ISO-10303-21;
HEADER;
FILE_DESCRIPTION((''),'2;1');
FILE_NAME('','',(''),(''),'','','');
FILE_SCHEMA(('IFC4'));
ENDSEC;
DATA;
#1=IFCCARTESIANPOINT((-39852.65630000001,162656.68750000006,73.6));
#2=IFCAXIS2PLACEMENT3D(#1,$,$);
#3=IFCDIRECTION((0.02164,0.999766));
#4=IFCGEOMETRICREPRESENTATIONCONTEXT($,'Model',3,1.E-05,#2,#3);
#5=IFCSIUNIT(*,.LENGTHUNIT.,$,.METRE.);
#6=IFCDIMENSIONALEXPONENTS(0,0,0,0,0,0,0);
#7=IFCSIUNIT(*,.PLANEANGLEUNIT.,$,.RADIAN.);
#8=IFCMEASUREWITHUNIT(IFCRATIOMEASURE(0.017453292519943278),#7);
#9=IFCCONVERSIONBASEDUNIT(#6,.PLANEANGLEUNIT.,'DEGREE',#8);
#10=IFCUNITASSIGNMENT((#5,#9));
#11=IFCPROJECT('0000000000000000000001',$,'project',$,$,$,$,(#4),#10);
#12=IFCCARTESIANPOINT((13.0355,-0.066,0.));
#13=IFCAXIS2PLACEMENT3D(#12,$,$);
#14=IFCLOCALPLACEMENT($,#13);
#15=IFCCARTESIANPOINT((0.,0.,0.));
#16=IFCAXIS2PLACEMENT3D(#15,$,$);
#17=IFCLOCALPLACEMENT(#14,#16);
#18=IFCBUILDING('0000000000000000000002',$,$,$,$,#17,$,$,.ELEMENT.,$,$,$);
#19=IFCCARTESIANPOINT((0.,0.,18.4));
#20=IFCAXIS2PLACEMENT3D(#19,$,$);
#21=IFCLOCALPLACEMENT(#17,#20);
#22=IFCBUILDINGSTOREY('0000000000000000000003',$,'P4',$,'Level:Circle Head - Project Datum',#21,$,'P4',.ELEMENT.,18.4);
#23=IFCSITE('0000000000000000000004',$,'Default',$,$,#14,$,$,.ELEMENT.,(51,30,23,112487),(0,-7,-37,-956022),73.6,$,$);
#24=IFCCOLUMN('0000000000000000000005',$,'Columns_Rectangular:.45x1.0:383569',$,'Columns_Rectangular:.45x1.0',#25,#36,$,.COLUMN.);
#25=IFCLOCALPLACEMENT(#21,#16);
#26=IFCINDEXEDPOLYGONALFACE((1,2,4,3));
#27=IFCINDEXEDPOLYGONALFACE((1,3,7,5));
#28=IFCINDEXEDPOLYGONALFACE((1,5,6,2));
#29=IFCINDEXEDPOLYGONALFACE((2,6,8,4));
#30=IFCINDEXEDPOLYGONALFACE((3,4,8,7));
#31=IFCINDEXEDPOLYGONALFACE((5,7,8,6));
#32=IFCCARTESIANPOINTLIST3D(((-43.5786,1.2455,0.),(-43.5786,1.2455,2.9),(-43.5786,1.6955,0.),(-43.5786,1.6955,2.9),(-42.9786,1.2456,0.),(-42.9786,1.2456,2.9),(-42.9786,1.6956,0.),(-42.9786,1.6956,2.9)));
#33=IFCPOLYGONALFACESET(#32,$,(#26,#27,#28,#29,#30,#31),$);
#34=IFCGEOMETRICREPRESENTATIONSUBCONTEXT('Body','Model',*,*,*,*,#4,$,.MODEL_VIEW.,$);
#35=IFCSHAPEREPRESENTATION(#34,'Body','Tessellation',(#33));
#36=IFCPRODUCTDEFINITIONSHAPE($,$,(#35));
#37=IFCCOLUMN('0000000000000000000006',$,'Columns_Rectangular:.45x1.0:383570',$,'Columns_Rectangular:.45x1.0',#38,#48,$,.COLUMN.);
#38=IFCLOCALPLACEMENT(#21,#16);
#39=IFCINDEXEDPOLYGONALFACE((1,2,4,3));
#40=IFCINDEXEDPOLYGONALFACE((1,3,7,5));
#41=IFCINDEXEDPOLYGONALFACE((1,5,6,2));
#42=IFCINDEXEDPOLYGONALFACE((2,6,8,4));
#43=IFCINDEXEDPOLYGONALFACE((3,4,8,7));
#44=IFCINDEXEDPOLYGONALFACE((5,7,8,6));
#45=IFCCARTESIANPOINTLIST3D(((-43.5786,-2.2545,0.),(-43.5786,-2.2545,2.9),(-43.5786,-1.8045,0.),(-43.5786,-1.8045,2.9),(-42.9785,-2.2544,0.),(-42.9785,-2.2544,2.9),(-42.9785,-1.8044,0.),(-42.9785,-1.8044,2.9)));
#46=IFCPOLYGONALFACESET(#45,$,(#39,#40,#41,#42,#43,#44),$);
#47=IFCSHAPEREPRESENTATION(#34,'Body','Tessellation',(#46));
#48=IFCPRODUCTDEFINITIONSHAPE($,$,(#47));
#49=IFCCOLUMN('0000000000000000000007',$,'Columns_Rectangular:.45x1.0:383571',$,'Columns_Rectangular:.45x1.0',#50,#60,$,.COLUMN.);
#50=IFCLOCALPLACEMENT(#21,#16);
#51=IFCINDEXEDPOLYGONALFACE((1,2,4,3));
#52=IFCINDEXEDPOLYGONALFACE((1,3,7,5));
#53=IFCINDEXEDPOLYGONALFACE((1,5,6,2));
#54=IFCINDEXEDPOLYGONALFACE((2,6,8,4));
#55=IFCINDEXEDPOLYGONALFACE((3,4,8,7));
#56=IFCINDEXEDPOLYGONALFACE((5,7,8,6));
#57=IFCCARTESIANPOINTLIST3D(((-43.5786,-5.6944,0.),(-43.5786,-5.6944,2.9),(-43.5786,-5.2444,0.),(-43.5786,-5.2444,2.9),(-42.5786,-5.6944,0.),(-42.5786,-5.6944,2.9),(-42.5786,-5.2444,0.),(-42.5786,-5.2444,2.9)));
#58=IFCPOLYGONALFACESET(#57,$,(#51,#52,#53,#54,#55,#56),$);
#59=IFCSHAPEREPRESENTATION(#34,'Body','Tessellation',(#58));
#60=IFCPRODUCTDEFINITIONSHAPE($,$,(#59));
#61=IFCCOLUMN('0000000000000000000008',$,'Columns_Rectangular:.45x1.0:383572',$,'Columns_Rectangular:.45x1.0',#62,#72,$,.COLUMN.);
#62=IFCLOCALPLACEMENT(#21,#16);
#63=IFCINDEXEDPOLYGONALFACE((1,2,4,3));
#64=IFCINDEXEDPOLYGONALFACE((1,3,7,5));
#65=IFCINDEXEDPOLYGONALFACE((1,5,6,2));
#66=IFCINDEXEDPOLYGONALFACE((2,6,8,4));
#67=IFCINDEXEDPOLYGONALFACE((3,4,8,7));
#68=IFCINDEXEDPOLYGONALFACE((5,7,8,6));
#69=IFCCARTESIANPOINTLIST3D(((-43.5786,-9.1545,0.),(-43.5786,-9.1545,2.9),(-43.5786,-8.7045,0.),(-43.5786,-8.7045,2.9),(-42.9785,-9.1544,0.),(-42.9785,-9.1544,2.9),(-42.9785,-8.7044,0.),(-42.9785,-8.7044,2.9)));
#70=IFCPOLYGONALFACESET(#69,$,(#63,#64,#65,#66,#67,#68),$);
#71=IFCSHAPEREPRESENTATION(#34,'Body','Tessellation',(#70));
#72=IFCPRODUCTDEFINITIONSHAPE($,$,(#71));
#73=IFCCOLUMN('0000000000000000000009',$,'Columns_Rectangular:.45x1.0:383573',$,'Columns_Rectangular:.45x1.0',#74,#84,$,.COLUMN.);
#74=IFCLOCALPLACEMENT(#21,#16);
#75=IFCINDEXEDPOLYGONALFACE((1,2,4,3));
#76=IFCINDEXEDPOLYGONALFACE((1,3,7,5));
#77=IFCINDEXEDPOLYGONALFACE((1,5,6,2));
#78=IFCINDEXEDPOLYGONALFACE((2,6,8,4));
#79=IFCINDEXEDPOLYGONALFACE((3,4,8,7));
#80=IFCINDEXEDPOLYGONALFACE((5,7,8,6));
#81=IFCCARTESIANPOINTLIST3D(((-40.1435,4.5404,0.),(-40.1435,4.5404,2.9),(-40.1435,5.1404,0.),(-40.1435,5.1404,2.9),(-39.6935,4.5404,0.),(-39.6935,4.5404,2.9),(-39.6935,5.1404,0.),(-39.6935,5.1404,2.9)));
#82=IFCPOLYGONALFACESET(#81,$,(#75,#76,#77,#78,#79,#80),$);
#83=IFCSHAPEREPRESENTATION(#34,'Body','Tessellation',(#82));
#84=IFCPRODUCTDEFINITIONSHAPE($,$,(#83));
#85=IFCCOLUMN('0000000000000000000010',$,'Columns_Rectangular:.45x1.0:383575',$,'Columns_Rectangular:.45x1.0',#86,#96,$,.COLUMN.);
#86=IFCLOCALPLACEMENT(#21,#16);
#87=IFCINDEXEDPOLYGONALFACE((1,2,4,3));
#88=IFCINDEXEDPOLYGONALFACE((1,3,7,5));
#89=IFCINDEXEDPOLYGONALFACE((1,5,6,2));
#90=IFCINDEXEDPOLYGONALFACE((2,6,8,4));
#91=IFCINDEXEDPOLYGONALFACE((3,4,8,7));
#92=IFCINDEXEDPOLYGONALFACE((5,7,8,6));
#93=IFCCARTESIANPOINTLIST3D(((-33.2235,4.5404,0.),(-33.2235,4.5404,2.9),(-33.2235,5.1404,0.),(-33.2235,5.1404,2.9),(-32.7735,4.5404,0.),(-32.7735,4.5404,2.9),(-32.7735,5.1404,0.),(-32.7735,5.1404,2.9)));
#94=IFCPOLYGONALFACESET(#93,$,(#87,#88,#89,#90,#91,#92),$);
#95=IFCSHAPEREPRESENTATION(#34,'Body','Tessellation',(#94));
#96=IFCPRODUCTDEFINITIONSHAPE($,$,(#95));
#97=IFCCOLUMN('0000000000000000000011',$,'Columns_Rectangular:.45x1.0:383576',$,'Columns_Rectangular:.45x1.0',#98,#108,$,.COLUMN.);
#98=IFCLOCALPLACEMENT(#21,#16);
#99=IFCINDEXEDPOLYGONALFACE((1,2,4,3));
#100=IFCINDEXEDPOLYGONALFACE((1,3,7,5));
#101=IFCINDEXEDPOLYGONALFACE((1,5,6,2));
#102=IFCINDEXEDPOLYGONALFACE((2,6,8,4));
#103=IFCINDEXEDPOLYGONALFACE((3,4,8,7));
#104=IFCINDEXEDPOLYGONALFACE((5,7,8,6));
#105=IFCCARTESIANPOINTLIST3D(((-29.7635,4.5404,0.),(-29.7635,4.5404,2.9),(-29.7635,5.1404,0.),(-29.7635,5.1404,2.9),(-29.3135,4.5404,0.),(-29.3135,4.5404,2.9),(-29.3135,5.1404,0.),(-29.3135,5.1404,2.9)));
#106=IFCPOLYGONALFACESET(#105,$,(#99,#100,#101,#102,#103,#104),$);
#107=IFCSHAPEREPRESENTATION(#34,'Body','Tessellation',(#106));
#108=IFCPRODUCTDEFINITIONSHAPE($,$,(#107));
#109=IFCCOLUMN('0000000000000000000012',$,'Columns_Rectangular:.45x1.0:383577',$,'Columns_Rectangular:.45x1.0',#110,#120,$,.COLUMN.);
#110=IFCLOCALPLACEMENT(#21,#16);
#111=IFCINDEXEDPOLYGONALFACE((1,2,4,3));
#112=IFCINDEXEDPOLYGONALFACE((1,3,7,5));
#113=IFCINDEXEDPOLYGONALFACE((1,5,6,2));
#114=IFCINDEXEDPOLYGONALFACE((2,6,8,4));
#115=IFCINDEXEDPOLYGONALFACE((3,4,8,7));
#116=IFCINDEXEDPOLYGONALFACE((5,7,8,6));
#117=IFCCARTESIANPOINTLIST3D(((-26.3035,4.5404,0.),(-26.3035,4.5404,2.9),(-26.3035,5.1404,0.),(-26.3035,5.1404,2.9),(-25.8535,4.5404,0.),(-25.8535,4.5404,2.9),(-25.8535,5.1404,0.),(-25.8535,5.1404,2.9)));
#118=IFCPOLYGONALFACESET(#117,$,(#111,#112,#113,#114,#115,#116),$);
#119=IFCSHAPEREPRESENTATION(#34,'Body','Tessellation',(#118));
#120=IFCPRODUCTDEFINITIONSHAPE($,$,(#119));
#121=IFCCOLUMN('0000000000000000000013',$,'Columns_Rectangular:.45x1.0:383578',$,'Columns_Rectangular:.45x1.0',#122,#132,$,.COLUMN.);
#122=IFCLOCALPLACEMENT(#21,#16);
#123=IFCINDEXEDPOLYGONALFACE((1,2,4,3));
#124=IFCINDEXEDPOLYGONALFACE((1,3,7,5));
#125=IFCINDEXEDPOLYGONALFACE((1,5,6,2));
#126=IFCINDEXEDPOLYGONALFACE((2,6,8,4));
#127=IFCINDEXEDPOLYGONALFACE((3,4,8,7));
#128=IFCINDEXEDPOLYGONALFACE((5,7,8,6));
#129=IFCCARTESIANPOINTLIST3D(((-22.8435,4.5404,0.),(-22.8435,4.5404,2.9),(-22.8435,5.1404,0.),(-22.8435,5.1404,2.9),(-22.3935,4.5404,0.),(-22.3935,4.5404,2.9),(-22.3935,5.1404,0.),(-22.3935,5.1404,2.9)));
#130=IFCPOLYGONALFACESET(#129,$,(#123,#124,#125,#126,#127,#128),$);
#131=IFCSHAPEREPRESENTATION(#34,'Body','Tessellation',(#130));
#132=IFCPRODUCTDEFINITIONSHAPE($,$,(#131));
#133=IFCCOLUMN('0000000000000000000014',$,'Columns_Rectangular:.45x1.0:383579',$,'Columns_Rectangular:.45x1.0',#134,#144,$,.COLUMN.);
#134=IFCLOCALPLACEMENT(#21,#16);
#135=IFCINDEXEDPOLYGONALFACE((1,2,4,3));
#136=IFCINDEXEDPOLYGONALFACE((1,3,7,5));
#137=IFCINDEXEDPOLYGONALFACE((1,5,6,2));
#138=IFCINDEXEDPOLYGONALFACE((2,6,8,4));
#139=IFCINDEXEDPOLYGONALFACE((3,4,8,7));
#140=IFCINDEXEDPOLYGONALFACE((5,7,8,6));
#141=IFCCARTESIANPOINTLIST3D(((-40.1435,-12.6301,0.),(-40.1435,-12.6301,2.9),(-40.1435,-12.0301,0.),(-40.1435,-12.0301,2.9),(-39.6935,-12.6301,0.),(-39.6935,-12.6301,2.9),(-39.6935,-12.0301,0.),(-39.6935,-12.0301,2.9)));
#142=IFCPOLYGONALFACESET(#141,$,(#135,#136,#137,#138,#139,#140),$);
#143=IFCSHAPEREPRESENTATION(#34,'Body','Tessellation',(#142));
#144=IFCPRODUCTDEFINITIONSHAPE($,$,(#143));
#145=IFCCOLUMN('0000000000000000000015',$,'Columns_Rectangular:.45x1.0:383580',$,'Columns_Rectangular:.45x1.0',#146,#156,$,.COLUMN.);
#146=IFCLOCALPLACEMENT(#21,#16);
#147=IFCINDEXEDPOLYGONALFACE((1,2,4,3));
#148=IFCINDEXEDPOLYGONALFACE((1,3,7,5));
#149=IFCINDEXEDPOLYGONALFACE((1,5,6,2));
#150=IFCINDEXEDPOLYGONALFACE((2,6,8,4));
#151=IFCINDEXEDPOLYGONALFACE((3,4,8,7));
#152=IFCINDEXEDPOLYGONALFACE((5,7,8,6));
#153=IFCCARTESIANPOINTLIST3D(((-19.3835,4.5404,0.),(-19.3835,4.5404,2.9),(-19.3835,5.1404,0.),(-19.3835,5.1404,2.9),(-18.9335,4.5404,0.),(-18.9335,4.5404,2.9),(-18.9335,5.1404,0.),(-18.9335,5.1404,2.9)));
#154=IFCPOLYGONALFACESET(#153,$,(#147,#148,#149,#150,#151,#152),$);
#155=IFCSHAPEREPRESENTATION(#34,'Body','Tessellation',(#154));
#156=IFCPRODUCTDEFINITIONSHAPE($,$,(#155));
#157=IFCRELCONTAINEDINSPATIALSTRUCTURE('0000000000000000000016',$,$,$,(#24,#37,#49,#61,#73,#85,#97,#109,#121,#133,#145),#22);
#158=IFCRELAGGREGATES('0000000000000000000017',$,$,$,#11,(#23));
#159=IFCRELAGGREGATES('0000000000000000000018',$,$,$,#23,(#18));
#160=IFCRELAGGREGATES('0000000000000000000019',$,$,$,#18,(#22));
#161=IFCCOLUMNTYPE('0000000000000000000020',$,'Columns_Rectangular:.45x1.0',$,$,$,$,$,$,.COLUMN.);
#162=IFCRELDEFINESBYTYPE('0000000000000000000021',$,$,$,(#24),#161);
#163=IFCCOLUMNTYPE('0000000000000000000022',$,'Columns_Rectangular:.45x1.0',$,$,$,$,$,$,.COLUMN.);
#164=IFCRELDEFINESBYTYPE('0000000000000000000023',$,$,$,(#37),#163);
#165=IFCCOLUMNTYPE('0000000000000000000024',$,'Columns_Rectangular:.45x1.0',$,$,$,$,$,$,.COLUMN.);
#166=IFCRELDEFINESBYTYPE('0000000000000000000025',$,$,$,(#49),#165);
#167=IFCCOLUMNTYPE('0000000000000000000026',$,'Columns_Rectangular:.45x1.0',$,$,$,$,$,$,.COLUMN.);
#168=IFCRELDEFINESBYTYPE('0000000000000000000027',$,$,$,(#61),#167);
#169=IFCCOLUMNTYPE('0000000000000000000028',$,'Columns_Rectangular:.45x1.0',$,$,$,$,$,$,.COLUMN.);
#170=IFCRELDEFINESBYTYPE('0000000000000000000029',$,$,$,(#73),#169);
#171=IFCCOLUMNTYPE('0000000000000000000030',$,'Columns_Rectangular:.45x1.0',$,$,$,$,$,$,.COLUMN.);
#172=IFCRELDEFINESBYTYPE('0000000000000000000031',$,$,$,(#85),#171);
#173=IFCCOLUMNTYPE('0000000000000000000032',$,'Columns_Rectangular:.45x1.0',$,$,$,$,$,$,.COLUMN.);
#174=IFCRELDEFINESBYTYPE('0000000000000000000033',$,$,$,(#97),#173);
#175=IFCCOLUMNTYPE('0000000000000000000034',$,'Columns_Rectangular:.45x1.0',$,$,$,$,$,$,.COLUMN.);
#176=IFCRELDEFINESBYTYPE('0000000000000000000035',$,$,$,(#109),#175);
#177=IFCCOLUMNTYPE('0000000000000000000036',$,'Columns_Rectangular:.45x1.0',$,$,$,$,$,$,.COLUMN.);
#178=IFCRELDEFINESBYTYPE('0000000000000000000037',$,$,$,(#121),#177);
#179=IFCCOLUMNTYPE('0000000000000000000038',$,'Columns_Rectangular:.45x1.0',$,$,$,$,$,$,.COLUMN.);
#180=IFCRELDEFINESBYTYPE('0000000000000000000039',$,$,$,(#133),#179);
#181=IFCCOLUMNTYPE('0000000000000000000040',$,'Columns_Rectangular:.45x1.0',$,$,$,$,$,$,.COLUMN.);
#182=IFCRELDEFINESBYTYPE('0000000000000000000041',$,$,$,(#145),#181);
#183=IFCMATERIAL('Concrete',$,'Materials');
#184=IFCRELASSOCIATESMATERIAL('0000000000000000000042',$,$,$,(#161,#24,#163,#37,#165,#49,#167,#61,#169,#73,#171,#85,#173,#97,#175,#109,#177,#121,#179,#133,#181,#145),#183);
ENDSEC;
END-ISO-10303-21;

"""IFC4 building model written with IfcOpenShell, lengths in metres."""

from ifc_helpers import new_model, entity, si_unit, converted_unit, direction, frame, origin, place, context, subcontext, project, spatial, indexed_curve, outline, extrude, source, transform, mapped, material, type_object, type_shapes, element, save


model = new_model("IFC4")

# Units and contexts
model_context = context("Model", 3, precision=1e-05, world=frame((-39852.65630000001, 162656.68750000006, 73.6)), true_north=direction((0.02164, 0.999766)))
body_context = subcontext(model_context, "Body", "Model", "MODEL_VIEW")
ifc_project = project(units=[si_unit("LENGTHUNIT", "METRE"), converted_unit("PLANEANGLEUNIT", "DEGREE", entity("IfcRatioMeasure", 0.017453292519943278), si_unit("PLANEANGLEUNIT", "RADIAN"), dimensions=[0, 0, 0, 0, 0, 0, 0])], contexts=[model_context])

# Site, building, storey
site_placement = place(None, frame((13.0355, -0.066, 0.0)))
site = spatial("IfcSite", under=ifc_project, at=site_placement, Name="Default", CompositionType="ELEMENT", RefLatitude=(51, 30, 23, 112487), RefLongitude=(0, -7, -37, -956022), RefElevation=73.6)
building_placement = place(site_placement, origin())
building = spatial("IfcBuilding", under=site, at=building_placement, CompositionType="ELEMENT")
storey_placement = place(building_placement, frame((0.0, 0.0, 18.4)))
storey = spatial("IfcBuildingStorey", under=building, at=storey_placement, Name="P4", ObjectType="Level:Circle Head - Project Datum", LongName="P4", CompositionType="ELEMENT", Elevation=18.4)

# Columns
ifc_material = material(Name="Concrete", Category="Materials")
column_type_1 = type_object("IfcColumnType", Name="Columns_Rectangular:.45x1.0", PredefinedType="COLUMN", material=ifc_material)
shared_shape_1 = source(origin(), body_context, "Body", "SweptSolid", [
    extrude(outline(indexed_curve([(-0.3, -0.225), (0.3, -0.225), (0.3, 0.225), (-0.3, 0.225), (-0.3, -0.225)], self_intersect=False)), frame((-43.2786, 1.4706, 18.4), z_axis=(0.0, 0.0, 1.0), x_axis=(-1.0, -0.000005, 0.0)), (0.0, 0.0, 1.0), 2.9),
])
type_shapes(column_type_1, [shared_shape_1])
column_1_placement = place(storey_placement, frame((0.0, 0.0, -18.4)))
element("IfcColumn", 1, at=column_1_placement, inside=storey, type_object=column_type_1, material=ifc_material, Name="Columns_Rectangular:.45x1.0:383569", ObjectType="Columns_Rectangular:.45x1.0", PredefinedType="COLUMN", context=body_context, shape_type="MappedRepresentation", body=[
    mapped(shared_shape_1, transform((0.0, 0.0, 0.0), scale=1.0)),
])
column_type_2 = type_object("IfcColumnType", Name="Columns_Rectangular:.45x1.0", PredefinedType="COLUMN", material=ifc_material)
shared_shape_2 = source(origin(), body_context, "Body", "SweptSolid", [
    extrude(outline(indexed_curve([(-0.3, -0.225), (0.3, -0.225), (0.3, 0.225), (-0.3, 0.225), (-0.3, -0.225)], self_intersect=False)), frame((-43.2785, -2.0294, 18.4), z_axis=(0.0, 0.0, 1.0), x_axis=(-1.0, -0.000005, 0.0)), (0.0, 0.0, 1.0), 2.9),
])
type_shapes(column_type_2, [shared_shape_2])
column_2_placement = place(storey_placement, frame((0.0, 0.0, -18.4)))
element("IfcColumn", 2, at=column_2_placement, inside=storey, type_object=column_type_2, material=ifc_material, Name="Columns_Rectangular:.45x1.0:383570", ObjectType="Columns_Rectangular:.45x1.0", PredefinedType="COLUMN", context=body_context, shape_type="MappedRepresentation", body=[
    mapped(shared_shape_2, transform((0.0, 0.0, 0.0), scale=1.0)),
])
column_type_3 = type_object("IfcColumnType", Name="Columns_Rectangular:.45x1.0", PredefinedType="COLUMN", material=ifc_material)
shared_shape_3 = source(origin(), body_context, "Body", "SweptSolid", [
    extrude(outline(indexed_curve([(-0.225, -0.5), (0.225, -0.5), (0.225, 0.5), (-0.225, 0.5), (-0.225, -0.5)], self_intersect=False)), frame((-43.0786, -5.4694, 18.4), z_axis=(0.0, 0.0, 1.0), x_axis=(0.0, -1.0, 0.0)), (0.0, 0.0, 1.0), 2.9),
])
type_shapes(column_type_3, [shared_shape_3])
column_3_placement = place(storey_placement, frame((0.0, 0.0, -18.4)))
element("IfcColumn", 3, at=column_3_placement, inside=storey, type_object=column_type_3, material=ifc_material, Name="Columns_Rectangular:.45x1.0:383571", ObjectType="Columns_Rectangular:.45x1.0", PredefinedType="COLUMN", context=body_context, shape_type="MappedRepresentation", body=[
    mapped(shared_shape_3, transform((0.0, 0.0, 0.0), scale=1.0)),
])
column_type_4 = type_object("IfcColumnType", Name="Columns_Rectangular:.45x1.0", PredefinedType="COLUMN", material=ifc_material)
shared_shape_4 = source(origin(), body_context, "Body", "SweptSolid", [
    extrude(outline(indexed_curve([(-0.3, -0.225), (0.3, -0.225), (0.3, 0.225), (-0.3, 0.225), (-0.3, -0.225)], self_intersect=False)), frame((-43.2785, -8.9294, 18.4), z_axis=(0.0, 0.0, 1.0), x_axis=(-1.0, -0.000005, 0.0)), (0.0, 0.0, 1.0), 2.9),
])
type_shapes(column_type_4, [shared_shape_4])
column_4_placement = place(storey_placement, frame((0.0, 0.0, -18.4)))
element("IfcColumn", 4, at=column_4_placement, inside=storey, type_object=column_type_4, material=ifc_material, Name="Columns_Rectangular:.45x1.0:383572", ObjectType="Columns_Rectangular:.45x1.0", PredefinedType="COLUMN", context=body_context, shape_type="MappedRepresentation", body=[
    mapped(shared_shape_4, transform((0.0, 0.0, 0.0), scale=1.0)),
])
column_type_5 = type_object("IfcColumnType", Name="Columns_Rectangular:.45x1.0", PredefinedType="COLUMN", material=ifc_material)
shared_shape_5 = source(origin(), body_context, "Body", "SweptSolid", [
    extrude(outline(indexed_curve([(-0.3, -0.225), (0.3, -0.225), (0.3, 0.225), (-0.3, 0.225), (-0.3, -0.225)], self_intersect=False)), frame((-39.9185, 4.8404, 18.4), z_axis=(0.0, 0.0, 1.0), x_axis=(0.0, -1.0, 0.0)), (0.0, 0.0, 1.0), 2.9),
])
type_shapes(column_type_5, [shared_shape_5])
column_5_placement = place(storey_placement, frame((0.0, 0.0, -18.4)))
element("IfcColumn", 5, at=column_5_placement, inside=storey, type_object=column_type_5, material=ifc_material, Name="Columns_Rectangular:.45x1.0:383573", ObjectType="Columns_Rectangular:.45x1.0", PredefinedType="COLUMN", context=body_context, shape_type="MappedRepresentation", body=[
    mapped(shared_shape_5, transform((0.0, 0.0, 0.0), scale=1.0)),
])
column_type_6 = type_object("IfcColumnType", Name="Columns_Rectangular:.45x1.0", PredefinedType="COLUMN", material=ifc_material)
shared_shape_6 = source(origin(), body_context, "Body", "SweptSolid", [
    extrude(outline(indexed_curve([(-0.3, -0.225), (0.3, -0.225), (0.3, 0.225), (-0.3, 0.225), (-0.3, -0.225)], self_intersect=False)), frame((-32.9985, 4.8404, 18.4), z_axis=(0.0, 0.0, 1.0), x_axis=(0.0, -1.0, 0.0)), (0.0, 0.0, 1.0), 2.9),
])
type_shapes(column_type_6, [shared_shape_6])
column_6_placement = place(storey_placement, frame((0.0, 0.0, -18.4)))
element("IfcColumn", 6, at=column_6_placement, inside=storey, type_object=column_type_6, material=ifc_material, Name="Columns_Rectangular:.45x1.0:383575", ObjectType="Columns_Rectangular:.45x1.0", PredefinedType="COLUMN", context=body_context, shape_type="MappedRepresentation", body=[
    mapped(shared_shape_6, transform((0.0, 0.0, 0.0), scale=1.0)),
])
column_type_7 = type_object("IfcColumnType", Name="Columns_Rectangular:.45x1.0", PredefinedType="COLUMN", material=ifc_material)
shared_shape_7 = source(origin(), body_context, "Body", "SweptSolid", [
    extrude(outline(indexed_curve([(-0.3, -0.225), (0.3, -0.225), (0.3, 0.225), (-0.3, 0.225), (-0.3, -0.225)], self_intersect=False)), frame((-29.5385, 4.8404, 18.4), z_axis=(0.0, 0.0, 1.0), x_axis=(0.0, -1.0, 0.0)), (0.0, 0.0, 1.0), 2.9),
])
type_shapes(column_type_7, [shared_shape_7])
column_7_placement = place(storey_placement, frame((0.0, 0.0, -18.4)))
element("IfcColumn", 7, at=column_7_placement, inside=storey, type_object=column_type_7, material=ifc_material, Name="Columns_Rectangular:.45x1.0:383576", ObjectType="Columns_Rectangular:.45x1.0", PredefinedType="COLUMN", context=body_context, shape_type="MappedRepresentation", body=[
    mapped(shared_shape_7, transform((0.0, 0.0, 0.0), scale=1.0)),
])
column_type_8 = type_object("IfcColumnType", Name="Columns_Rectangular:.45x1.0", PredefinedType="COLUMN", material=ifc_material)
shared_shape_8 = source(origin(), body_context, "Body", "SweptSolid", [
    extrude(outline(indexed_curve([(-0.3, -0.225), (0.3, -0.225), (0.3, 0.225), (-0.3, 0.225), (-0.3, -0.225)], self_intersect=False)), frame((-26.0785, 4.8404, 18.4), z_axis=(0.0, 0.0, 1.0), x_axis=(0.0, -1.0, 0.0)), (0.0, 0.0, 1.0), 2.9),
])
type_shapes(column_type_8, [shared_shape_8])
column_8_placement = place(storey_placement, frame((0.0, 0.0, -18.4)))
element("IfcColumn", 8, at=column_8_placement, inside=storey, type_object=column_type_8, material=ifc_material, Name="Columns_Rectangular:.45x1.0:383577", ObjectType="Columns_Rectangular:.45x1.0", PredefinedType="COLUMN", context=body_context, shape_type="MappedRepresentation", body=[
    mapped(shared_shape_8, transform((0.0, 0.0, 0.0), scale=1.0)),
])
column_type_9 = type_object("IfcColumnType", Name="Columns_Rectangular:.45x1.0", PredefinedType="COLUMN", material=ifc_material)
shared_shape_9 = source(origin(), body_context, "Body", "SweptSolid", [
    extrude(outline(indexed_curve([(-0.3, -0.225), (0.3, -0.225), (0.3, 0.225), (-0.3, 0.225), (-0.3, -0.225)], self_intersect=False)), frame((-22.6185, 4.8404, 18.4), z_axis=(0.0, 0.0, 1.0), x_axis=(0.0, -1.0, 0.0)), (0.0, 0.0, 1.0), 2.9),
])
type_shapes(column_type_9, [shared_shape_9])
column_9_placement = place(storey_placement, frame((0.0, 0.0, -18.4)))
element("IfcColumn", 9, at=column_9_placement, inside=storey, type_object=column_type_9, material=ifc_material, Name="Columns_Rectangular:.45x1.0:383578", ObjectType="Columns_Rectangular:.45x1.0", PredefinedType="COLUMN", context=body_context, shape_type="MappedRepresentation", body=[
    mapped(shared_shape_9, transform((0.0, 0.0, 0.0), scale=1.0)),
])
column_type_10 = type_object("IfcColumnType", Name="Columns_Rectangular:.45x1.0", PredefinedType="COLUMN", material=ifc_material)
shared_shape_10 = source(origin(), body_context, "Body", "SweptSolid", [
    extrude(outline(indexed_curve([(-0.3, -0.225), (0.3, -0.225), (0.3, 0.225), (-0.3, 0.225), (-0.3, -0.225)], self_intersect=False)), frame((-39.9185, -12.3301, 18.4), z_axis=(0.0, 0.0, 1.0), x_axis=(0.000011, 1.0, 0.0)), (0.0, 0.0, 1.0), 2.9),
])
type_shapes(column_type_10, [shared_shape_10])
column_10_placement = place(storey_placement, frame((0.0, 0.0, -18.4)))
element("IfcColumn", 10, at=column_10_placement, inside=storey, type_object=column_type_10, material=ifc_material, Name="Columns_Rectangular:.45x1.0:383579", ObjectType="Columns_Rectangular:.45x1.0", PredefinedType="COLUMN", context=body_context, shape_type="MappedRepresentation", body=[
    mapped(shared_shape_10, transform((0.0, 0.0, 0.0), scale=1.0)),
])
column_type_11 = type_object("IfcColumnType", Name="Columns_Rectangular:.45x1.0", PredefinedType="COLUMN", material=ifc_material)
shared_shape_11 = source(origin(), body_context, "Body", "SweptSolid", [
    extrude(outline(indexed_curve([(-0.3, -0.225), (0.3, -0.225), (0.3, 0.225), (-0.3, 0.225), (-0.3, -0.225)], self_intersect=False)), frame((-19.1585, 4.8404, 18.4), z_axis=(0.0, 0.0, 1.0), x_axis=(0.0, -1.0, 0.0)), (0.0, 0.0, 1.0), 2.9),
])
type_shapes(column_type_11, [shared_shape_11])
column_11_placement = place(storey_placement, frame((0.0, 0.0, -18.4)))
element("IfcColumn", 11, at=column_11_placement, inside=storey, type_object=column_type_11, material=ifc_material, Name="Columns_Rectangular:.45x1.0:383580", ObjectType="Columns_Rectangular:.45x1.0", PredefinedType="COLUMN", context=body_context, shape_type="MappedRepresentation", body=[
    mapped(shared_shape_11, transform((0.0, 0.0, 0.0), scale=1.0)),
])

save(model, "model.ifc")
